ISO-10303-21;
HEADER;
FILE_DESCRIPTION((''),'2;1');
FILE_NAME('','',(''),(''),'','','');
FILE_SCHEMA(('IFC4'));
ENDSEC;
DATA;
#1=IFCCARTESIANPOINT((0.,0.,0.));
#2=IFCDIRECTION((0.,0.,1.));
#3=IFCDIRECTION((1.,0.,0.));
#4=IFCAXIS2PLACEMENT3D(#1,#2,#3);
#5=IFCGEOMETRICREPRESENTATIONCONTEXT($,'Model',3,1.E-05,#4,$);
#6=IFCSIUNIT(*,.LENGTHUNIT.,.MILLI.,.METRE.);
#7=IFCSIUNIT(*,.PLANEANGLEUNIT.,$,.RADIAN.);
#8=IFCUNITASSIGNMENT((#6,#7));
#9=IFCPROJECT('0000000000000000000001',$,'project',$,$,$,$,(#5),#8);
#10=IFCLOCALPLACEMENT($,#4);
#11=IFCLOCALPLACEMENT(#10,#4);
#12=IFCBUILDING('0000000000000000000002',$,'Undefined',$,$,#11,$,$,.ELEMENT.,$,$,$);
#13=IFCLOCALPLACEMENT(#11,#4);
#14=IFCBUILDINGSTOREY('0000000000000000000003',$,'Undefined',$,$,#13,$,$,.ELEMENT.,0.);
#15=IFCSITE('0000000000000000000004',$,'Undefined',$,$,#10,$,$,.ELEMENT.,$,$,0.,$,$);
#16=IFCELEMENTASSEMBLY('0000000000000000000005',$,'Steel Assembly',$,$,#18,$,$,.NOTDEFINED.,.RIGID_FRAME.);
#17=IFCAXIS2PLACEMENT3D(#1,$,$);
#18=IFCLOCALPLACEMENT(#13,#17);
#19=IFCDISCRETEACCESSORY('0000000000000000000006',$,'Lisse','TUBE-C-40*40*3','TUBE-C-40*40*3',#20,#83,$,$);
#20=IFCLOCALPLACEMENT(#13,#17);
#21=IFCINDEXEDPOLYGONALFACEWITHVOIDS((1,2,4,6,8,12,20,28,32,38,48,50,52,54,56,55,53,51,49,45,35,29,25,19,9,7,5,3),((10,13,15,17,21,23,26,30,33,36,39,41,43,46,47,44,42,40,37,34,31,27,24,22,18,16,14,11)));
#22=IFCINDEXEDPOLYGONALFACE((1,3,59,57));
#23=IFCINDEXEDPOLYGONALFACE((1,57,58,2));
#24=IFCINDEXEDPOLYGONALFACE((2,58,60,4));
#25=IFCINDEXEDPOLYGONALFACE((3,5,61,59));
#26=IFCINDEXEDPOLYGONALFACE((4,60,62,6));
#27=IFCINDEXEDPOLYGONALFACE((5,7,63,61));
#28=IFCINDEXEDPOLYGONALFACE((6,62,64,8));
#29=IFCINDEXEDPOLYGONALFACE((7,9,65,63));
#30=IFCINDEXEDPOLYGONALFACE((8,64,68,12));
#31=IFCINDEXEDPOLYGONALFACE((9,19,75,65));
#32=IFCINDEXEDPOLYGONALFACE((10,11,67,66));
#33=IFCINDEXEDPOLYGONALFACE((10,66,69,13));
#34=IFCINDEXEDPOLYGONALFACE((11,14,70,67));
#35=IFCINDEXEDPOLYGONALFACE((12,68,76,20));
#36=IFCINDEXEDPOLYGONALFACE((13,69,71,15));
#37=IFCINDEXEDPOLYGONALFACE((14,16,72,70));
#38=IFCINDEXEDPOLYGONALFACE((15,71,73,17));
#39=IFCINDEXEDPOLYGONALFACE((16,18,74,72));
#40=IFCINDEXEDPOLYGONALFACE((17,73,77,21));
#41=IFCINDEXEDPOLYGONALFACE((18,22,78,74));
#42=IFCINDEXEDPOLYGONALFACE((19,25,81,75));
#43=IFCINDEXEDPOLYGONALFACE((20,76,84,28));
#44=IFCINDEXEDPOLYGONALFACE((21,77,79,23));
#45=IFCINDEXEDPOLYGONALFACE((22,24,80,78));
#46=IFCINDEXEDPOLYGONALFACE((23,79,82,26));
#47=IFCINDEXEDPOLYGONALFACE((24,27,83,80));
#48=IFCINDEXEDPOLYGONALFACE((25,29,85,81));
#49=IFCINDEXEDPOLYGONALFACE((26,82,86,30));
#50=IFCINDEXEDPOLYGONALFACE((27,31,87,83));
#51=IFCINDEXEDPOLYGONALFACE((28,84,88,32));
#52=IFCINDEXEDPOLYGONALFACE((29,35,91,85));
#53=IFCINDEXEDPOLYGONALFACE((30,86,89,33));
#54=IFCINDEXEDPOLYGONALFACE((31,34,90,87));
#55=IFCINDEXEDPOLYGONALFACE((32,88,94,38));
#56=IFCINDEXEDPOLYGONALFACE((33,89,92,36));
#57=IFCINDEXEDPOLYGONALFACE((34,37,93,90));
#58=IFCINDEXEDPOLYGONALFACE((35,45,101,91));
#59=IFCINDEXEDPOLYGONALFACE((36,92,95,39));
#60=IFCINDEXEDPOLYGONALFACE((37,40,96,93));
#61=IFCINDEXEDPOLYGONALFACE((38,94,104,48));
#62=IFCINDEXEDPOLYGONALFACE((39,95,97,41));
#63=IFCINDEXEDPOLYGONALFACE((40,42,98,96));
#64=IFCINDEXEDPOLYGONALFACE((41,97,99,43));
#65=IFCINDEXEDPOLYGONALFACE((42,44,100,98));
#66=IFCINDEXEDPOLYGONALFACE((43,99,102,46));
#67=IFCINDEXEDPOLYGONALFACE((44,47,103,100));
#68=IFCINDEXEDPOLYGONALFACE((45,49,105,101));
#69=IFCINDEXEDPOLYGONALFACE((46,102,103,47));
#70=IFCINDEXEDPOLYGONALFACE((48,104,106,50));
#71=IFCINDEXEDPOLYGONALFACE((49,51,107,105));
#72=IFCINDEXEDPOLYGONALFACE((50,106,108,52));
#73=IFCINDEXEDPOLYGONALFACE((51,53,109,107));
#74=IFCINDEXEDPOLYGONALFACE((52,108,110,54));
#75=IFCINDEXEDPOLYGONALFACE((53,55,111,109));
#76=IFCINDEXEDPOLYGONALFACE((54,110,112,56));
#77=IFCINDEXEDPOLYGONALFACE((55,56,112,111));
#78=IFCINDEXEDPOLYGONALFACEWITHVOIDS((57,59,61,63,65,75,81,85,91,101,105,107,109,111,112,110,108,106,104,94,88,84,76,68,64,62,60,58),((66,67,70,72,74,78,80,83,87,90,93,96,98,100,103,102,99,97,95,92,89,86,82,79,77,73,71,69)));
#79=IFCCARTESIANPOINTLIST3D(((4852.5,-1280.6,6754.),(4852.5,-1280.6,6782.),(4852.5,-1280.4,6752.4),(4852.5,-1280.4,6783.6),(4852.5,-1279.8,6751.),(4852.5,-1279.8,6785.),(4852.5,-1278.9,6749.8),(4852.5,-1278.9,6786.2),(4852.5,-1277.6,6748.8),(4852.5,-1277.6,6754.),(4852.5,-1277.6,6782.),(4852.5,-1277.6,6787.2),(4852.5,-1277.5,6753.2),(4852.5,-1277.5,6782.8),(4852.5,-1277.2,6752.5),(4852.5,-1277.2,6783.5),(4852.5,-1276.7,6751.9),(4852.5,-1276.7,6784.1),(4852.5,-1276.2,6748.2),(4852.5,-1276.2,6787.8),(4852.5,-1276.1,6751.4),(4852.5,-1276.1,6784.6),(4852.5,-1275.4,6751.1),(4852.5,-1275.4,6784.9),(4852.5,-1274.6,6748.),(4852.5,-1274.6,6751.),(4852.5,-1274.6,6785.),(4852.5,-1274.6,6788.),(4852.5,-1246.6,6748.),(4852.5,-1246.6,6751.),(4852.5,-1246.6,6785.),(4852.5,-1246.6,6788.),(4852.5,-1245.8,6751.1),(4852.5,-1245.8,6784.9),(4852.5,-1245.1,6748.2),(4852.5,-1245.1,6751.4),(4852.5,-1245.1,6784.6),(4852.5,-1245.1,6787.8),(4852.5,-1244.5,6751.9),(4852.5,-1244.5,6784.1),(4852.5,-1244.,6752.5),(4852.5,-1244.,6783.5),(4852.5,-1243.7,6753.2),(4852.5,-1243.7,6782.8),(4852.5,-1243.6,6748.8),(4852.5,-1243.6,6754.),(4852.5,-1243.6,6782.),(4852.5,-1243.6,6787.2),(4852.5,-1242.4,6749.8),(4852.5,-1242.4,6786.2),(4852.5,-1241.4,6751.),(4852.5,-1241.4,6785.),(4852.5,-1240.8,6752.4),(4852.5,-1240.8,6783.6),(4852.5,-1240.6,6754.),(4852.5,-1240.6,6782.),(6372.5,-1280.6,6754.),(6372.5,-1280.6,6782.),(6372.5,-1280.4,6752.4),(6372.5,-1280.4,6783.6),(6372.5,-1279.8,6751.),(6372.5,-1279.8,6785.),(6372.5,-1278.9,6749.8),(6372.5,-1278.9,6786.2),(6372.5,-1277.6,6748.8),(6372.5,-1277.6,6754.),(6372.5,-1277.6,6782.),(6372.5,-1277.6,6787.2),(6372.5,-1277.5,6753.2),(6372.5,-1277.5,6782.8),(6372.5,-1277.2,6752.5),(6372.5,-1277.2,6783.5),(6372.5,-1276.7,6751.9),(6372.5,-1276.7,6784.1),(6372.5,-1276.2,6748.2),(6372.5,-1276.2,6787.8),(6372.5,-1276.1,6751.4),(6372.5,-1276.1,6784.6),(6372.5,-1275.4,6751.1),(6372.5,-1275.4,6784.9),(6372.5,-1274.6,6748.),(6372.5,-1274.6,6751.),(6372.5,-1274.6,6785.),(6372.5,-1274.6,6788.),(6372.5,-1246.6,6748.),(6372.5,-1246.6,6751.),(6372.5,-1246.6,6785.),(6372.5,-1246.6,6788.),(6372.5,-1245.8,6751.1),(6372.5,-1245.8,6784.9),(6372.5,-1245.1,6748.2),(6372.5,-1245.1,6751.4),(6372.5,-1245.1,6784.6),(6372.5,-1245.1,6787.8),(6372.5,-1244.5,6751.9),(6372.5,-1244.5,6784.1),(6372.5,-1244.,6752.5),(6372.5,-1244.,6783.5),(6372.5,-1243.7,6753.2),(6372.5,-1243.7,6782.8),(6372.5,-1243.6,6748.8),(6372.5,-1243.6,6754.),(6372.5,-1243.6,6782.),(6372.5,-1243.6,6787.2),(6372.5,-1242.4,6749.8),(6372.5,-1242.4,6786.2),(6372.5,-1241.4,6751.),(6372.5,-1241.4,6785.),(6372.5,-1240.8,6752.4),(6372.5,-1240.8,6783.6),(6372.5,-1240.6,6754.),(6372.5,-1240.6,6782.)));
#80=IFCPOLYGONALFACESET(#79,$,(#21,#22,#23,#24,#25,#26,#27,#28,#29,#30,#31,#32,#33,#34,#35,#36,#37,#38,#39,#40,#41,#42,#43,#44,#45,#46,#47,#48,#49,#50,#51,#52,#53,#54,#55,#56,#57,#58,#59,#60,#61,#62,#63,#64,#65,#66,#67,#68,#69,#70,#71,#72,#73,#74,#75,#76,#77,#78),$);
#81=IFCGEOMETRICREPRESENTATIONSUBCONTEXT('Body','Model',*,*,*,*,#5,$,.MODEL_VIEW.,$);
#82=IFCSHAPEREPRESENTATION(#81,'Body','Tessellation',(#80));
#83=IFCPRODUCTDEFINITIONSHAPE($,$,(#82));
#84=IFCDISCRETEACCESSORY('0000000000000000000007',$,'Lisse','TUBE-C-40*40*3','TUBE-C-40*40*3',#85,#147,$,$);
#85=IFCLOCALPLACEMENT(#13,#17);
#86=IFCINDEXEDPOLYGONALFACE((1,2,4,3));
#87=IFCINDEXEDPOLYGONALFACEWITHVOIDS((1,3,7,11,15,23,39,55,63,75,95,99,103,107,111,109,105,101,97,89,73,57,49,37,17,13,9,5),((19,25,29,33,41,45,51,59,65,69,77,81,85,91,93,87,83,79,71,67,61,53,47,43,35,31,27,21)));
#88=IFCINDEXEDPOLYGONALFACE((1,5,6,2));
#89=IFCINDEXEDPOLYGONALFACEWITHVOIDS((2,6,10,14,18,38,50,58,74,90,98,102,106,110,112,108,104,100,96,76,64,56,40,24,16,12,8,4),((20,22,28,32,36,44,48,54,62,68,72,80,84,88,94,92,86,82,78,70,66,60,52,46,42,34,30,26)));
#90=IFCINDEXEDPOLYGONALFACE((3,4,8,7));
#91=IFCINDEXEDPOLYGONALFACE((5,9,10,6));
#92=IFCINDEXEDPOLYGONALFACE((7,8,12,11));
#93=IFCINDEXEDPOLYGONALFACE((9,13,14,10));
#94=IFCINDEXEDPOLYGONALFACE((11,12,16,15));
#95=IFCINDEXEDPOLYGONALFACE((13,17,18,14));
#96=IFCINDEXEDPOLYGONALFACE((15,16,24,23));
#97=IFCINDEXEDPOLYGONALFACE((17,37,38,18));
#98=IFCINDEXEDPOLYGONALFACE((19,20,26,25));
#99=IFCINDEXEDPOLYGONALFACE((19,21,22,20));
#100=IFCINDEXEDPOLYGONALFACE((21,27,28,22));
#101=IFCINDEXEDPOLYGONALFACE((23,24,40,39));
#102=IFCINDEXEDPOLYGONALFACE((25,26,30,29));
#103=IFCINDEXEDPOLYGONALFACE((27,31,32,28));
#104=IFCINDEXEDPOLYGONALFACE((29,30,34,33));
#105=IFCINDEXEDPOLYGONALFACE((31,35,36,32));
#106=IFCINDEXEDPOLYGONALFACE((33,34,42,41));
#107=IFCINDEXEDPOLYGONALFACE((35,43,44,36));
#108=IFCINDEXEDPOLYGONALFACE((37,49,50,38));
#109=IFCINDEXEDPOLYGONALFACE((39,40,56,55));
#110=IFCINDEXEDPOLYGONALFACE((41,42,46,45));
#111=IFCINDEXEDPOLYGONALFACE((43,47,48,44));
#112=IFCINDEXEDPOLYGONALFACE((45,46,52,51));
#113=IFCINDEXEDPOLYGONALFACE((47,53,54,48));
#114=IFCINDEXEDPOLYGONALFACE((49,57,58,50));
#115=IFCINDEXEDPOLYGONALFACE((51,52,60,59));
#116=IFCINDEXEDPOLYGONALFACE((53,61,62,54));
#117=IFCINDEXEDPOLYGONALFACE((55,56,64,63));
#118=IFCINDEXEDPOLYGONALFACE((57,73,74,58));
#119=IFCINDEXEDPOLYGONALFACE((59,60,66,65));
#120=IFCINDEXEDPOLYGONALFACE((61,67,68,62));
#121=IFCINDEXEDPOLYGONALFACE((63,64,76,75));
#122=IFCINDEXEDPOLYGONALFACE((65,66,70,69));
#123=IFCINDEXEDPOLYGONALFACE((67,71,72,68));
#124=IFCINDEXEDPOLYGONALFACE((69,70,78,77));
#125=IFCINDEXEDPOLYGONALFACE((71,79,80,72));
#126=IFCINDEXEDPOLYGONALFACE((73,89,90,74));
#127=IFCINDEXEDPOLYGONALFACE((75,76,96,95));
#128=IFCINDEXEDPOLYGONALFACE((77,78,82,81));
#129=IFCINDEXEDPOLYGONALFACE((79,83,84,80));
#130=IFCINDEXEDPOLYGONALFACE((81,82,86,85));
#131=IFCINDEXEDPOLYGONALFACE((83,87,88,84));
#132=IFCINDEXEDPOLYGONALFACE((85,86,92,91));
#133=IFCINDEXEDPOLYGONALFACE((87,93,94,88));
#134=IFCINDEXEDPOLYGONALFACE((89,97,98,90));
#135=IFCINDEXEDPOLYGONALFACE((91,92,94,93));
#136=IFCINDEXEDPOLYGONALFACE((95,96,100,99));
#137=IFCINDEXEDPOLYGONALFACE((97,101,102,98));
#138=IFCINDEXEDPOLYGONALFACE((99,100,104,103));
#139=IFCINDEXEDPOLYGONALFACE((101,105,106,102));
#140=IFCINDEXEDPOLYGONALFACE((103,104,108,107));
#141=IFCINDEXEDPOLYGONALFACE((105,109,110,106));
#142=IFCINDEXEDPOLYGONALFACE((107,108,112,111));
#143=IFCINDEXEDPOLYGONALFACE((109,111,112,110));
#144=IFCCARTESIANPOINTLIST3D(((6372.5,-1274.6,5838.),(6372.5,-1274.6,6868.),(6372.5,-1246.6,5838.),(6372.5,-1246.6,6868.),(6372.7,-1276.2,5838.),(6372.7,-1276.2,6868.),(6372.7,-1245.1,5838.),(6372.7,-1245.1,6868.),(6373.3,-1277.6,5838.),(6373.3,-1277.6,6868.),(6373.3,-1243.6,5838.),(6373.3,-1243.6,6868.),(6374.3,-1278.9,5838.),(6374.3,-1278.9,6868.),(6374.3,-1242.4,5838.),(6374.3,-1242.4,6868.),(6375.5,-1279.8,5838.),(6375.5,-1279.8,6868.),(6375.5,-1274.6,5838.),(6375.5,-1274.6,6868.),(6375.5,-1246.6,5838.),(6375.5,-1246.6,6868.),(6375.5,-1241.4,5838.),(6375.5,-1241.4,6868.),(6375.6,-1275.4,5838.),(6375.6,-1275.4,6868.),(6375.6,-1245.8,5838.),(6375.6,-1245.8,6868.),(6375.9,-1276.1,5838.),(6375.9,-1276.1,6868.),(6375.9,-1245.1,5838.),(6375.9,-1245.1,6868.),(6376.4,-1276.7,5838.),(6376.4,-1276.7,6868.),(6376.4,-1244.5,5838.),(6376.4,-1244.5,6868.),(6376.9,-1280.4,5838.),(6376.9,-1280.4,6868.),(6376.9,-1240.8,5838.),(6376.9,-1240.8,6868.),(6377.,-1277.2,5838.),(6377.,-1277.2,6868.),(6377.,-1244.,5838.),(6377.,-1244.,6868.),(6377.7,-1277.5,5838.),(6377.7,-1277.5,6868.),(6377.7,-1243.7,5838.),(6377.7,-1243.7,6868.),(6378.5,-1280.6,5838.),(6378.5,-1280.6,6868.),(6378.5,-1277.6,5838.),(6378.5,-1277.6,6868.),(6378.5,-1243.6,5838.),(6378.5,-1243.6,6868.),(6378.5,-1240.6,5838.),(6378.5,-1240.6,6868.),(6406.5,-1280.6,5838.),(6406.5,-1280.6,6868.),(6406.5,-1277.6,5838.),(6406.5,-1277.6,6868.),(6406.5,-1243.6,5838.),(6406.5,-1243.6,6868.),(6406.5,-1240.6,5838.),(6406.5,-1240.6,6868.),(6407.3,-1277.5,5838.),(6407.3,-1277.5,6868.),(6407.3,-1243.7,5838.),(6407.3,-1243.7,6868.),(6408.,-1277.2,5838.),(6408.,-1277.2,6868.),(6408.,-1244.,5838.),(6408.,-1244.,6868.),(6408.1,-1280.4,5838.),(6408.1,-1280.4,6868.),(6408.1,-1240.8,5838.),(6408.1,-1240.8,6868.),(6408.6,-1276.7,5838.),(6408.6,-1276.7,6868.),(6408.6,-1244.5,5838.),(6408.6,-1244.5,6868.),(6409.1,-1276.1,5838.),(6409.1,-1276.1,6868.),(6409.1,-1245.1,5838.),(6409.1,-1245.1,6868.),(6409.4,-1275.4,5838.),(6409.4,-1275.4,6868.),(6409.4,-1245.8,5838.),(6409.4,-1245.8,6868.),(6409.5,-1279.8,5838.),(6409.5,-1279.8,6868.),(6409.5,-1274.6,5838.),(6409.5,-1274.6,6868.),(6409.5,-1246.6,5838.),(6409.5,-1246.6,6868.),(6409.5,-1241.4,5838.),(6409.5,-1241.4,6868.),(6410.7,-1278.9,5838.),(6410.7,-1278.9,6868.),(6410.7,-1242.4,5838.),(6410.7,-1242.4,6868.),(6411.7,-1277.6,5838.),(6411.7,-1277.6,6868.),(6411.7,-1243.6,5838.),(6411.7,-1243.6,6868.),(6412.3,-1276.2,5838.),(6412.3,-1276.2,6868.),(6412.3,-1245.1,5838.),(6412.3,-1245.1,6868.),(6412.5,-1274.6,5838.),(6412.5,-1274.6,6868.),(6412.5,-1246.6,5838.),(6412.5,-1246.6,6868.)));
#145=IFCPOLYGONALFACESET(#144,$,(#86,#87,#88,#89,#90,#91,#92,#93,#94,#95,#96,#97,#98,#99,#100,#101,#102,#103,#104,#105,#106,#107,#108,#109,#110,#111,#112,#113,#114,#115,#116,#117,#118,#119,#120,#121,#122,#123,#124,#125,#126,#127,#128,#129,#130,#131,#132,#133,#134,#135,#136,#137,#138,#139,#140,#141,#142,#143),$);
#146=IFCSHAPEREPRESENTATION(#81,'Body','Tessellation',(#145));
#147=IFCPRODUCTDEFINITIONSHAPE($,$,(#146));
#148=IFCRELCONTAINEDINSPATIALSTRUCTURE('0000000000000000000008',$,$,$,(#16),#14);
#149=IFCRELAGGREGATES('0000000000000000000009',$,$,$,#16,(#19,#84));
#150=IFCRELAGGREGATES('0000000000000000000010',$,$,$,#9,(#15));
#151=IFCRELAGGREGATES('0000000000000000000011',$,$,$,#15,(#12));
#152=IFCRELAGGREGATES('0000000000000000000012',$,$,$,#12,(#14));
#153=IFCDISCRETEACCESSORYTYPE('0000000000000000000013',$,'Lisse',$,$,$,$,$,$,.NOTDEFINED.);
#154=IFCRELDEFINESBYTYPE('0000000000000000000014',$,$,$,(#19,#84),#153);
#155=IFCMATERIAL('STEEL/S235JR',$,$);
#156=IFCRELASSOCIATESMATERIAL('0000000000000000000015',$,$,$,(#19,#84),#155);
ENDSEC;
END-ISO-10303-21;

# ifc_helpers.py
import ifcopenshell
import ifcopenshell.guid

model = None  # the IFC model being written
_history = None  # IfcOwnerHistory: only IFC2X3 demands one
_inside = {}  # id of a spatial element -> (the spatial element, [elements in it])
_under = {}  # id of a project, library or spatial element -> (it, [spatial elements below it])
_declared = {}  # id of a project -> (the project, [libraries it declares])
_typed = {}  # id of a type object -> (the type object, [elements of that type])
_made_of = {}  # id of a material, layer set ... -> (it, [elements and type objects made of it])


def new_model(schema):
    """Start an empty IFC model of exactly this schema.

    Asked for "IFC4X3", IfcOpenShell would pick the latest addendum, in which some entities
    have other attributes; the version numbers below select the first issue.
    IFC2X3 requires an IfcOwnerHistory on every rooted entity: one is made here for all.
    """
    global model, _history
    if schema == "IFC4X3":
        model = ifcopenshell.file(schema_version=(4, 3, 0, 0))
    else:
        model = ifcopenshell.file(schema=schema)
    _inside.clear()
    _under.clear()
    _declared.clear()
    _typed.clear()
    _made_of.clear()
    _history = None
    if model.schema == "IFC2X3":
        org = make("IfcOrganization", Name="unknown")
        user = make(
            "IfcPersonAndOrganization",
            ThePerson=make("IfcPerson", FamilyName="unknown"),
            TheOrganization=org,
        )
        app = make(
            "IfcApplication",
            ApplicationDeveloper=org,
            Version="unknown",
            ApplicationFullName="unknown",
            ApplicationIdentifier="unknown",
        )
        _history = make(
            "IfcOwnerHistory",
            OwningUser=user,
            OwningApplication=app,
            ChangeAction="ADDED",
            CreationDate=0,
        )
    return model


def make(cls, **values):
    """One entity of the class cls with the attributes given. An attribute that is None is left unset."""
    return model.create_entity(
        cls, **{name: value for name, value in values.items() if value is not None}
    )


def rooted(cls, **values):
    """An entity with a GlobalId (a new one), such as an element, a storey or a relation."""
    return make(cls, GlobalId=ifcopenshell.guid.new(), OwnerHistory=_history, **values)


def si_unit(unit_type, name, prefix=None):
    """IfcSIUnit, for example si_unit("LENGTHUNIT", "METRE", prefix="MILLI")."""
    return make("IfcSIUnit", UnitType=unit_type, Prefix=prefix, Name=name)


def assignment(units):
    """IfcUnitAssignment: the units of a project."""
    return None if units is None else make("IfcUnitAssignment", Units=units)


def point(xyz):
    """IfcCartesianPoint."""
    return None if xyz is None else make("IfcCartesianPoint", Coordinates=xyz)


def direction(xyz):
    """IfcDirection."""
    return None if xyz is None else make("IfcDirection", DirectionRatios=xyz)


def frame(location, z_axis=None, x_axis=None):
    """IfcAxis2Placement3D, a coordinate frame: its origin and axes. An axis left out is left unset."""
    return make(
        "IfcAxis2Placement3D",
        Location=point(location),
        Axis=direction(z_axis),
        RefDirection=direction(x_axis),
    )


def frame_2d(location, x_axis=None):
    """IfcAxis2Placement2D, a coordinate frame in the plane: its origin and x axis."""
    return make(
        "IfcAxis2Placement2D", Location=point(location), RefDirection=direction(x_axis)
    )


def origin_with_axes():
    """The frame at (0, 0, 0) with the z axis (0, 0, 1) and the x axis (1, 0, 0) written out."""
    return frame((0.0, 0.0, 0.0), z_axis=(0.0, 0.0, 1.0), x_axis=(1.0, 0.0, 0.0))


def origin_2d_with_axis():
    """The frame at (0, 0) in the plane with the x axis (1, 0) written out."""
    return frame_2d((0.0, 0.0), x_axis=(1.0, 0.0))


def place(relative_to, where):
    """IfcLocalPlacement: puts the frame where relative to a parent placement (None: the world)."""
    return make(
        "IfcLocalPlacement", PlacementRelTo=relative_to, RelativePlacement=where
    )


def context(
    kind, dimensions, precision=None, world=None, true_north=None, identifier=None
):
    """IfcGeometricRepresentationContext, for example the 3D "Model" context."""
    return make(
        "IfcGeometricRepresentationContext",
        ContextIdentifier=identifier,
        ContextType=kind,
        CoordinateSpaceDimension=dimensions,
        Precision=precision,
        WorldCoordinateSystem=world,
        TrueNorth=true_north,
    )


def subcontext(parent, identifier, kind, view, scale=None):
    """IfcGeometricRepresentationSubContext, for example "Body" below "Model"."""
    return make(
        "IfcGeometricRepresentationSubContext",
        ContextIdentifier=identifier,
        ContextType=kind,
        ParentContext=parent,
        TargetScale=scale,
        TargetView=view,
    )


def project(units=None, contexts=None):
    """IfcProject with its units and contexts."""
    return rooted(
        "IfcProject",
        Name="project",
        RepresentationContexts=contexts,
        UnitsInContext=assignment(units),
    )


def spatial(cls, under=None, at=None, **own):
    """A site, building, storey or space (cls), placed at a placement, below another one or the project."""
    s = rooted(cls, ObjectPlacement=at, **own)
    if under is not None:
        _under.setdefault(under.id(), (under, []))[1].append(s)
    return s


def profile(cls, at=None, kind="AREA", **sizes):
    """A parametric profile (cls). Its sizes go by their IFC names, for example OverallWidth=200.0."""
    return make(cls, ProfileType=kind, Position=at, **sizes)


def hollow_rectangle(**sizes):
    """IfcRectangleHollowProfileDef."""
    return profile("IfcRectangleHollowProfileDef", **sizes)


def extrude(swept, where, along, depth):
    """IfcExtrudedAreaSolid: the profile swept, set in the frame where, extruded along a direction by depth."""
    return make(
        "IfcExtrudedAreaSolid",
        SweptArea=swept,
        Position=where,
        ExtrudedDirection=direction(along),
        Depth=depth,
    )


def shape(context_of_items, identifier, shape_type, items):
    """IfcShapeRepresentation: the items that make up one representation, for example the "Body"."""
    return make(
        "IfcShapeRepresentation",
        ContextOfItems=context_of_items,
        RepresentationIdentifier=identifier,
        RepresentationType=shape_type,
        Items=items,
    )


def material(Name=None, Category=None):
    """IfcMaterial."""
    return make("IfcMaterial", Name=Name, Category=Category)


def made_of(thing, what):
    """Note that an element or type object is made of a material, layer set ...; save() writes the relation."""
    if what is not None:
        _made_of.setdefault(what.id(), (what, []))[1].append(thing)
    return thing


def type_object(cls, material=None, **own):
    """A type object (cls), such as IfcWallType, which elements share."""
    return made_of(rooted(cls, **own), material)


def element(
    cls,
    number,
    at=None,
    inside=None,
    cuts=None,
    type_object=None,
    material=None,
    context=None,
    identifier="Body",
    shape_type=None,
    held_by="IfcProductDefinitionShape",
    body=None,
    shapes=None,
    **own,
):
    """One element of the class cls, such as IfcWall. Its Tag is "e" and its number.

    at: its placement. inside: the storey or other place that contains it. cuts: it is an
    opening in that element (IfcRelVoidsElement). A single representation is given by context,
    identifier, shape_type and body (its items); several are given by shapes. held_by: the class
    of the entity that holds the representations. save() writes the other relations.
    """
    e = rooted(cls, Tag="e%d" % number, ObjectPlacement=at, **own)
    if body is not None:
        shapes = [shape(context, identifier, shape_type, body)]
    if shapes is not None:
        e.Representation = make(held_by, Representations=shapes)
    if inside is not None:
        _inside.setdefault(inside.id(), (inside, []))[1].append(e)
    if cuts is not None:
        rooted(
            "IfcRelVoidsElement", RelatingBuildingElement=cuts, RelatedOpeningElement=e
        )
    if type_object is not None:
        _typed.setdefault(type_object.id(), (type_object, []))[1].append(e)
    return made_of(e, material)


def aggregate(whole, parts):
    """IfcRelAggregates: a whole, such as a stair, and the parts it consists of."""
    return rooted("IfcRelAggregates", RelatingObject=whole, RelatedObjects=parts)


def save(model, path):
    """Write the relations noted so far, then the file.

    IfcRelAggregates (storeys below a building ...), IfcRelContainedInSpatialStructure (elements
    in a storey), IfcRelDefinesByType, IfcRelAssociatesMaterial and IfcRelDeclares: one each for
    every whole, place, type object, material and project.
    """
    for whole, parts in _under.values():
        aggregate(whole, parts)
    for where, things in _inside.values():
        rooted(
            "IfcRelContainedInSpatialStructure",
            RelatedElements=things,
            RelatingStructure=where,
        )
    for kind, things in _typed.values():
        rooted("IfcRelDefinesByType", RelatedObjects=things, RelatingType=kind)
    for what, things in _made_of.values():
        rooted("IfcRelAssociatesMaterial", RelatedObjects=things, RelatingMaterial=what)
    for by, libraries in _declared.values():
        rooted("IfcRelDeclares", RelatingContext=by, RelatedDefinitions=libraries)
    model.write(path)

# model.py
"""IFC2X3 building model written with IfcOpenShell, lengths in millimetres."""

from ifc_helpers import new_model, si_unit, frame, origin_with_axes, origin_2d_with_axis, place, context, subcontext, project, spatial, hollow_rectangle, extrude, material, type_object, element, aggregate, save


model = new_model("IFC2X3")

# Units and contexts
model_context = context("Model", 3, precision=1e-05, world=origin_with_axes())
body_context = subcontext(model_context, "Body", "Model", "MODEL_VIEW")
ifc_project = project(units=[si_unit("LENGTHUNIT", "METRE", prefix="MILLI"), si_unit("PLANEANGLEUNIT", "RADIAN")], contexts=[model_context])

# Site, building, storey
site_placement = place(None, origin_with_axes())
site = spatial("IfcSite", under=ifc_project, at=site_placement, Name="Undefined", CompositionType="ELEMENT", RefElevation=0.0)
building_placement = place(site_placement, origin_with_axes())
building = spatial("IfcBuilding", under=site, at=building_placement, Name="Undefined", CompositionType="ELEMENT")
storey_placement = place(building_placement, origin_with_axes())
storey = spatial("IfcBuildingStorey", under=building, at=storey_placement, Name="Undefined", CompositionType="ELEMENT", Elevation=0.0)

# Element assembly
assembly_1_placement = place(storey_placement, origin_with_axes())
assembly_1 = element("IfcElementAssembly", 1, at=assembly_1_placement, inside=storey, Name="Steel Assembly", AssemblyPlace="NOTDEFINED", PredefinedType="RIGID_FRAME")
ifc_material_1 = material(Name="STEEL/S235JR")

# Discrete accessories
discrete_accessory_type_1 = type_object("IfcDiscreteAccessoryType", Name="Lisse")
discrete_accessory_1_placement = place(assembly_1_placement, frame((6372.5, -1260.6, 6768.0), z_axis=(0.0, 1.0, 0.0), x_axis=(-1.0, 0.0, 0.0)))
discrete_accessory_1 = element("IfcDiscreteAccessory", 2, at=discrete_accessory_1_placement, type_object=discrete_accessory_type_1, material=ifc_material_1, Name="Lisse", Description="TUBE-C-40*40*3", ObjectType="TUBE-C-40*40*3", context=body_context, shape_type="SweptSolid", body=[
    extrude(hollow_rectangle(XDim=40.0, YDim=40.0, WallThickness=3.0, InnerFilletRadius=3.0, OuterFilletRadius=6.0, at=origin_2d_with_axis()), frame((1520.0, 0.0, 0.0), z_axis=(-1.0, 0.0, 0.0), x_axis=(0.0, -1.0, 0.0)), (0.0, 0.0, 1.0), 1520.0),
])
discrete_accessory_2_placement = place(assembly_1_placement, frame((6392.5, -1260.6, 6868.0), z_axis=(0.0, 1.0, 0.0), x_axis=(0.0, 0.0, -1.0)))
discrete_accessory_2 = element("IfcDiscreteAccessory", 3, at=discrete_accessory_2_placement, type_object=discrete_accessory_type_1, material=ifc_material_1, Name="Lisse", Description="TUBE-C-40*40*3", ObjectType="TUBE-C-40*40*3", context=body_context, shape_type="SweptSolid", body=[
    extrude(hollow_rectangle(XDim=40.0, YDim=40.0, WallThickness=3.0, InnerFilletRadius=3.0, OuterFilletRadius=6.0, at=origin_2d_with_axis()), frame((1030.0, 0.0, 0.0), z_axis=(-1.0, 0.0, 0.0), x_axis=(0.0, -1.0, 0.0)), (0.0, 0.0, 1.0), 1030.0),
])
aggregate(assembly_1, [discrete_accessory_1, discrete_accessory_2])

save(model, "model.ifc")
